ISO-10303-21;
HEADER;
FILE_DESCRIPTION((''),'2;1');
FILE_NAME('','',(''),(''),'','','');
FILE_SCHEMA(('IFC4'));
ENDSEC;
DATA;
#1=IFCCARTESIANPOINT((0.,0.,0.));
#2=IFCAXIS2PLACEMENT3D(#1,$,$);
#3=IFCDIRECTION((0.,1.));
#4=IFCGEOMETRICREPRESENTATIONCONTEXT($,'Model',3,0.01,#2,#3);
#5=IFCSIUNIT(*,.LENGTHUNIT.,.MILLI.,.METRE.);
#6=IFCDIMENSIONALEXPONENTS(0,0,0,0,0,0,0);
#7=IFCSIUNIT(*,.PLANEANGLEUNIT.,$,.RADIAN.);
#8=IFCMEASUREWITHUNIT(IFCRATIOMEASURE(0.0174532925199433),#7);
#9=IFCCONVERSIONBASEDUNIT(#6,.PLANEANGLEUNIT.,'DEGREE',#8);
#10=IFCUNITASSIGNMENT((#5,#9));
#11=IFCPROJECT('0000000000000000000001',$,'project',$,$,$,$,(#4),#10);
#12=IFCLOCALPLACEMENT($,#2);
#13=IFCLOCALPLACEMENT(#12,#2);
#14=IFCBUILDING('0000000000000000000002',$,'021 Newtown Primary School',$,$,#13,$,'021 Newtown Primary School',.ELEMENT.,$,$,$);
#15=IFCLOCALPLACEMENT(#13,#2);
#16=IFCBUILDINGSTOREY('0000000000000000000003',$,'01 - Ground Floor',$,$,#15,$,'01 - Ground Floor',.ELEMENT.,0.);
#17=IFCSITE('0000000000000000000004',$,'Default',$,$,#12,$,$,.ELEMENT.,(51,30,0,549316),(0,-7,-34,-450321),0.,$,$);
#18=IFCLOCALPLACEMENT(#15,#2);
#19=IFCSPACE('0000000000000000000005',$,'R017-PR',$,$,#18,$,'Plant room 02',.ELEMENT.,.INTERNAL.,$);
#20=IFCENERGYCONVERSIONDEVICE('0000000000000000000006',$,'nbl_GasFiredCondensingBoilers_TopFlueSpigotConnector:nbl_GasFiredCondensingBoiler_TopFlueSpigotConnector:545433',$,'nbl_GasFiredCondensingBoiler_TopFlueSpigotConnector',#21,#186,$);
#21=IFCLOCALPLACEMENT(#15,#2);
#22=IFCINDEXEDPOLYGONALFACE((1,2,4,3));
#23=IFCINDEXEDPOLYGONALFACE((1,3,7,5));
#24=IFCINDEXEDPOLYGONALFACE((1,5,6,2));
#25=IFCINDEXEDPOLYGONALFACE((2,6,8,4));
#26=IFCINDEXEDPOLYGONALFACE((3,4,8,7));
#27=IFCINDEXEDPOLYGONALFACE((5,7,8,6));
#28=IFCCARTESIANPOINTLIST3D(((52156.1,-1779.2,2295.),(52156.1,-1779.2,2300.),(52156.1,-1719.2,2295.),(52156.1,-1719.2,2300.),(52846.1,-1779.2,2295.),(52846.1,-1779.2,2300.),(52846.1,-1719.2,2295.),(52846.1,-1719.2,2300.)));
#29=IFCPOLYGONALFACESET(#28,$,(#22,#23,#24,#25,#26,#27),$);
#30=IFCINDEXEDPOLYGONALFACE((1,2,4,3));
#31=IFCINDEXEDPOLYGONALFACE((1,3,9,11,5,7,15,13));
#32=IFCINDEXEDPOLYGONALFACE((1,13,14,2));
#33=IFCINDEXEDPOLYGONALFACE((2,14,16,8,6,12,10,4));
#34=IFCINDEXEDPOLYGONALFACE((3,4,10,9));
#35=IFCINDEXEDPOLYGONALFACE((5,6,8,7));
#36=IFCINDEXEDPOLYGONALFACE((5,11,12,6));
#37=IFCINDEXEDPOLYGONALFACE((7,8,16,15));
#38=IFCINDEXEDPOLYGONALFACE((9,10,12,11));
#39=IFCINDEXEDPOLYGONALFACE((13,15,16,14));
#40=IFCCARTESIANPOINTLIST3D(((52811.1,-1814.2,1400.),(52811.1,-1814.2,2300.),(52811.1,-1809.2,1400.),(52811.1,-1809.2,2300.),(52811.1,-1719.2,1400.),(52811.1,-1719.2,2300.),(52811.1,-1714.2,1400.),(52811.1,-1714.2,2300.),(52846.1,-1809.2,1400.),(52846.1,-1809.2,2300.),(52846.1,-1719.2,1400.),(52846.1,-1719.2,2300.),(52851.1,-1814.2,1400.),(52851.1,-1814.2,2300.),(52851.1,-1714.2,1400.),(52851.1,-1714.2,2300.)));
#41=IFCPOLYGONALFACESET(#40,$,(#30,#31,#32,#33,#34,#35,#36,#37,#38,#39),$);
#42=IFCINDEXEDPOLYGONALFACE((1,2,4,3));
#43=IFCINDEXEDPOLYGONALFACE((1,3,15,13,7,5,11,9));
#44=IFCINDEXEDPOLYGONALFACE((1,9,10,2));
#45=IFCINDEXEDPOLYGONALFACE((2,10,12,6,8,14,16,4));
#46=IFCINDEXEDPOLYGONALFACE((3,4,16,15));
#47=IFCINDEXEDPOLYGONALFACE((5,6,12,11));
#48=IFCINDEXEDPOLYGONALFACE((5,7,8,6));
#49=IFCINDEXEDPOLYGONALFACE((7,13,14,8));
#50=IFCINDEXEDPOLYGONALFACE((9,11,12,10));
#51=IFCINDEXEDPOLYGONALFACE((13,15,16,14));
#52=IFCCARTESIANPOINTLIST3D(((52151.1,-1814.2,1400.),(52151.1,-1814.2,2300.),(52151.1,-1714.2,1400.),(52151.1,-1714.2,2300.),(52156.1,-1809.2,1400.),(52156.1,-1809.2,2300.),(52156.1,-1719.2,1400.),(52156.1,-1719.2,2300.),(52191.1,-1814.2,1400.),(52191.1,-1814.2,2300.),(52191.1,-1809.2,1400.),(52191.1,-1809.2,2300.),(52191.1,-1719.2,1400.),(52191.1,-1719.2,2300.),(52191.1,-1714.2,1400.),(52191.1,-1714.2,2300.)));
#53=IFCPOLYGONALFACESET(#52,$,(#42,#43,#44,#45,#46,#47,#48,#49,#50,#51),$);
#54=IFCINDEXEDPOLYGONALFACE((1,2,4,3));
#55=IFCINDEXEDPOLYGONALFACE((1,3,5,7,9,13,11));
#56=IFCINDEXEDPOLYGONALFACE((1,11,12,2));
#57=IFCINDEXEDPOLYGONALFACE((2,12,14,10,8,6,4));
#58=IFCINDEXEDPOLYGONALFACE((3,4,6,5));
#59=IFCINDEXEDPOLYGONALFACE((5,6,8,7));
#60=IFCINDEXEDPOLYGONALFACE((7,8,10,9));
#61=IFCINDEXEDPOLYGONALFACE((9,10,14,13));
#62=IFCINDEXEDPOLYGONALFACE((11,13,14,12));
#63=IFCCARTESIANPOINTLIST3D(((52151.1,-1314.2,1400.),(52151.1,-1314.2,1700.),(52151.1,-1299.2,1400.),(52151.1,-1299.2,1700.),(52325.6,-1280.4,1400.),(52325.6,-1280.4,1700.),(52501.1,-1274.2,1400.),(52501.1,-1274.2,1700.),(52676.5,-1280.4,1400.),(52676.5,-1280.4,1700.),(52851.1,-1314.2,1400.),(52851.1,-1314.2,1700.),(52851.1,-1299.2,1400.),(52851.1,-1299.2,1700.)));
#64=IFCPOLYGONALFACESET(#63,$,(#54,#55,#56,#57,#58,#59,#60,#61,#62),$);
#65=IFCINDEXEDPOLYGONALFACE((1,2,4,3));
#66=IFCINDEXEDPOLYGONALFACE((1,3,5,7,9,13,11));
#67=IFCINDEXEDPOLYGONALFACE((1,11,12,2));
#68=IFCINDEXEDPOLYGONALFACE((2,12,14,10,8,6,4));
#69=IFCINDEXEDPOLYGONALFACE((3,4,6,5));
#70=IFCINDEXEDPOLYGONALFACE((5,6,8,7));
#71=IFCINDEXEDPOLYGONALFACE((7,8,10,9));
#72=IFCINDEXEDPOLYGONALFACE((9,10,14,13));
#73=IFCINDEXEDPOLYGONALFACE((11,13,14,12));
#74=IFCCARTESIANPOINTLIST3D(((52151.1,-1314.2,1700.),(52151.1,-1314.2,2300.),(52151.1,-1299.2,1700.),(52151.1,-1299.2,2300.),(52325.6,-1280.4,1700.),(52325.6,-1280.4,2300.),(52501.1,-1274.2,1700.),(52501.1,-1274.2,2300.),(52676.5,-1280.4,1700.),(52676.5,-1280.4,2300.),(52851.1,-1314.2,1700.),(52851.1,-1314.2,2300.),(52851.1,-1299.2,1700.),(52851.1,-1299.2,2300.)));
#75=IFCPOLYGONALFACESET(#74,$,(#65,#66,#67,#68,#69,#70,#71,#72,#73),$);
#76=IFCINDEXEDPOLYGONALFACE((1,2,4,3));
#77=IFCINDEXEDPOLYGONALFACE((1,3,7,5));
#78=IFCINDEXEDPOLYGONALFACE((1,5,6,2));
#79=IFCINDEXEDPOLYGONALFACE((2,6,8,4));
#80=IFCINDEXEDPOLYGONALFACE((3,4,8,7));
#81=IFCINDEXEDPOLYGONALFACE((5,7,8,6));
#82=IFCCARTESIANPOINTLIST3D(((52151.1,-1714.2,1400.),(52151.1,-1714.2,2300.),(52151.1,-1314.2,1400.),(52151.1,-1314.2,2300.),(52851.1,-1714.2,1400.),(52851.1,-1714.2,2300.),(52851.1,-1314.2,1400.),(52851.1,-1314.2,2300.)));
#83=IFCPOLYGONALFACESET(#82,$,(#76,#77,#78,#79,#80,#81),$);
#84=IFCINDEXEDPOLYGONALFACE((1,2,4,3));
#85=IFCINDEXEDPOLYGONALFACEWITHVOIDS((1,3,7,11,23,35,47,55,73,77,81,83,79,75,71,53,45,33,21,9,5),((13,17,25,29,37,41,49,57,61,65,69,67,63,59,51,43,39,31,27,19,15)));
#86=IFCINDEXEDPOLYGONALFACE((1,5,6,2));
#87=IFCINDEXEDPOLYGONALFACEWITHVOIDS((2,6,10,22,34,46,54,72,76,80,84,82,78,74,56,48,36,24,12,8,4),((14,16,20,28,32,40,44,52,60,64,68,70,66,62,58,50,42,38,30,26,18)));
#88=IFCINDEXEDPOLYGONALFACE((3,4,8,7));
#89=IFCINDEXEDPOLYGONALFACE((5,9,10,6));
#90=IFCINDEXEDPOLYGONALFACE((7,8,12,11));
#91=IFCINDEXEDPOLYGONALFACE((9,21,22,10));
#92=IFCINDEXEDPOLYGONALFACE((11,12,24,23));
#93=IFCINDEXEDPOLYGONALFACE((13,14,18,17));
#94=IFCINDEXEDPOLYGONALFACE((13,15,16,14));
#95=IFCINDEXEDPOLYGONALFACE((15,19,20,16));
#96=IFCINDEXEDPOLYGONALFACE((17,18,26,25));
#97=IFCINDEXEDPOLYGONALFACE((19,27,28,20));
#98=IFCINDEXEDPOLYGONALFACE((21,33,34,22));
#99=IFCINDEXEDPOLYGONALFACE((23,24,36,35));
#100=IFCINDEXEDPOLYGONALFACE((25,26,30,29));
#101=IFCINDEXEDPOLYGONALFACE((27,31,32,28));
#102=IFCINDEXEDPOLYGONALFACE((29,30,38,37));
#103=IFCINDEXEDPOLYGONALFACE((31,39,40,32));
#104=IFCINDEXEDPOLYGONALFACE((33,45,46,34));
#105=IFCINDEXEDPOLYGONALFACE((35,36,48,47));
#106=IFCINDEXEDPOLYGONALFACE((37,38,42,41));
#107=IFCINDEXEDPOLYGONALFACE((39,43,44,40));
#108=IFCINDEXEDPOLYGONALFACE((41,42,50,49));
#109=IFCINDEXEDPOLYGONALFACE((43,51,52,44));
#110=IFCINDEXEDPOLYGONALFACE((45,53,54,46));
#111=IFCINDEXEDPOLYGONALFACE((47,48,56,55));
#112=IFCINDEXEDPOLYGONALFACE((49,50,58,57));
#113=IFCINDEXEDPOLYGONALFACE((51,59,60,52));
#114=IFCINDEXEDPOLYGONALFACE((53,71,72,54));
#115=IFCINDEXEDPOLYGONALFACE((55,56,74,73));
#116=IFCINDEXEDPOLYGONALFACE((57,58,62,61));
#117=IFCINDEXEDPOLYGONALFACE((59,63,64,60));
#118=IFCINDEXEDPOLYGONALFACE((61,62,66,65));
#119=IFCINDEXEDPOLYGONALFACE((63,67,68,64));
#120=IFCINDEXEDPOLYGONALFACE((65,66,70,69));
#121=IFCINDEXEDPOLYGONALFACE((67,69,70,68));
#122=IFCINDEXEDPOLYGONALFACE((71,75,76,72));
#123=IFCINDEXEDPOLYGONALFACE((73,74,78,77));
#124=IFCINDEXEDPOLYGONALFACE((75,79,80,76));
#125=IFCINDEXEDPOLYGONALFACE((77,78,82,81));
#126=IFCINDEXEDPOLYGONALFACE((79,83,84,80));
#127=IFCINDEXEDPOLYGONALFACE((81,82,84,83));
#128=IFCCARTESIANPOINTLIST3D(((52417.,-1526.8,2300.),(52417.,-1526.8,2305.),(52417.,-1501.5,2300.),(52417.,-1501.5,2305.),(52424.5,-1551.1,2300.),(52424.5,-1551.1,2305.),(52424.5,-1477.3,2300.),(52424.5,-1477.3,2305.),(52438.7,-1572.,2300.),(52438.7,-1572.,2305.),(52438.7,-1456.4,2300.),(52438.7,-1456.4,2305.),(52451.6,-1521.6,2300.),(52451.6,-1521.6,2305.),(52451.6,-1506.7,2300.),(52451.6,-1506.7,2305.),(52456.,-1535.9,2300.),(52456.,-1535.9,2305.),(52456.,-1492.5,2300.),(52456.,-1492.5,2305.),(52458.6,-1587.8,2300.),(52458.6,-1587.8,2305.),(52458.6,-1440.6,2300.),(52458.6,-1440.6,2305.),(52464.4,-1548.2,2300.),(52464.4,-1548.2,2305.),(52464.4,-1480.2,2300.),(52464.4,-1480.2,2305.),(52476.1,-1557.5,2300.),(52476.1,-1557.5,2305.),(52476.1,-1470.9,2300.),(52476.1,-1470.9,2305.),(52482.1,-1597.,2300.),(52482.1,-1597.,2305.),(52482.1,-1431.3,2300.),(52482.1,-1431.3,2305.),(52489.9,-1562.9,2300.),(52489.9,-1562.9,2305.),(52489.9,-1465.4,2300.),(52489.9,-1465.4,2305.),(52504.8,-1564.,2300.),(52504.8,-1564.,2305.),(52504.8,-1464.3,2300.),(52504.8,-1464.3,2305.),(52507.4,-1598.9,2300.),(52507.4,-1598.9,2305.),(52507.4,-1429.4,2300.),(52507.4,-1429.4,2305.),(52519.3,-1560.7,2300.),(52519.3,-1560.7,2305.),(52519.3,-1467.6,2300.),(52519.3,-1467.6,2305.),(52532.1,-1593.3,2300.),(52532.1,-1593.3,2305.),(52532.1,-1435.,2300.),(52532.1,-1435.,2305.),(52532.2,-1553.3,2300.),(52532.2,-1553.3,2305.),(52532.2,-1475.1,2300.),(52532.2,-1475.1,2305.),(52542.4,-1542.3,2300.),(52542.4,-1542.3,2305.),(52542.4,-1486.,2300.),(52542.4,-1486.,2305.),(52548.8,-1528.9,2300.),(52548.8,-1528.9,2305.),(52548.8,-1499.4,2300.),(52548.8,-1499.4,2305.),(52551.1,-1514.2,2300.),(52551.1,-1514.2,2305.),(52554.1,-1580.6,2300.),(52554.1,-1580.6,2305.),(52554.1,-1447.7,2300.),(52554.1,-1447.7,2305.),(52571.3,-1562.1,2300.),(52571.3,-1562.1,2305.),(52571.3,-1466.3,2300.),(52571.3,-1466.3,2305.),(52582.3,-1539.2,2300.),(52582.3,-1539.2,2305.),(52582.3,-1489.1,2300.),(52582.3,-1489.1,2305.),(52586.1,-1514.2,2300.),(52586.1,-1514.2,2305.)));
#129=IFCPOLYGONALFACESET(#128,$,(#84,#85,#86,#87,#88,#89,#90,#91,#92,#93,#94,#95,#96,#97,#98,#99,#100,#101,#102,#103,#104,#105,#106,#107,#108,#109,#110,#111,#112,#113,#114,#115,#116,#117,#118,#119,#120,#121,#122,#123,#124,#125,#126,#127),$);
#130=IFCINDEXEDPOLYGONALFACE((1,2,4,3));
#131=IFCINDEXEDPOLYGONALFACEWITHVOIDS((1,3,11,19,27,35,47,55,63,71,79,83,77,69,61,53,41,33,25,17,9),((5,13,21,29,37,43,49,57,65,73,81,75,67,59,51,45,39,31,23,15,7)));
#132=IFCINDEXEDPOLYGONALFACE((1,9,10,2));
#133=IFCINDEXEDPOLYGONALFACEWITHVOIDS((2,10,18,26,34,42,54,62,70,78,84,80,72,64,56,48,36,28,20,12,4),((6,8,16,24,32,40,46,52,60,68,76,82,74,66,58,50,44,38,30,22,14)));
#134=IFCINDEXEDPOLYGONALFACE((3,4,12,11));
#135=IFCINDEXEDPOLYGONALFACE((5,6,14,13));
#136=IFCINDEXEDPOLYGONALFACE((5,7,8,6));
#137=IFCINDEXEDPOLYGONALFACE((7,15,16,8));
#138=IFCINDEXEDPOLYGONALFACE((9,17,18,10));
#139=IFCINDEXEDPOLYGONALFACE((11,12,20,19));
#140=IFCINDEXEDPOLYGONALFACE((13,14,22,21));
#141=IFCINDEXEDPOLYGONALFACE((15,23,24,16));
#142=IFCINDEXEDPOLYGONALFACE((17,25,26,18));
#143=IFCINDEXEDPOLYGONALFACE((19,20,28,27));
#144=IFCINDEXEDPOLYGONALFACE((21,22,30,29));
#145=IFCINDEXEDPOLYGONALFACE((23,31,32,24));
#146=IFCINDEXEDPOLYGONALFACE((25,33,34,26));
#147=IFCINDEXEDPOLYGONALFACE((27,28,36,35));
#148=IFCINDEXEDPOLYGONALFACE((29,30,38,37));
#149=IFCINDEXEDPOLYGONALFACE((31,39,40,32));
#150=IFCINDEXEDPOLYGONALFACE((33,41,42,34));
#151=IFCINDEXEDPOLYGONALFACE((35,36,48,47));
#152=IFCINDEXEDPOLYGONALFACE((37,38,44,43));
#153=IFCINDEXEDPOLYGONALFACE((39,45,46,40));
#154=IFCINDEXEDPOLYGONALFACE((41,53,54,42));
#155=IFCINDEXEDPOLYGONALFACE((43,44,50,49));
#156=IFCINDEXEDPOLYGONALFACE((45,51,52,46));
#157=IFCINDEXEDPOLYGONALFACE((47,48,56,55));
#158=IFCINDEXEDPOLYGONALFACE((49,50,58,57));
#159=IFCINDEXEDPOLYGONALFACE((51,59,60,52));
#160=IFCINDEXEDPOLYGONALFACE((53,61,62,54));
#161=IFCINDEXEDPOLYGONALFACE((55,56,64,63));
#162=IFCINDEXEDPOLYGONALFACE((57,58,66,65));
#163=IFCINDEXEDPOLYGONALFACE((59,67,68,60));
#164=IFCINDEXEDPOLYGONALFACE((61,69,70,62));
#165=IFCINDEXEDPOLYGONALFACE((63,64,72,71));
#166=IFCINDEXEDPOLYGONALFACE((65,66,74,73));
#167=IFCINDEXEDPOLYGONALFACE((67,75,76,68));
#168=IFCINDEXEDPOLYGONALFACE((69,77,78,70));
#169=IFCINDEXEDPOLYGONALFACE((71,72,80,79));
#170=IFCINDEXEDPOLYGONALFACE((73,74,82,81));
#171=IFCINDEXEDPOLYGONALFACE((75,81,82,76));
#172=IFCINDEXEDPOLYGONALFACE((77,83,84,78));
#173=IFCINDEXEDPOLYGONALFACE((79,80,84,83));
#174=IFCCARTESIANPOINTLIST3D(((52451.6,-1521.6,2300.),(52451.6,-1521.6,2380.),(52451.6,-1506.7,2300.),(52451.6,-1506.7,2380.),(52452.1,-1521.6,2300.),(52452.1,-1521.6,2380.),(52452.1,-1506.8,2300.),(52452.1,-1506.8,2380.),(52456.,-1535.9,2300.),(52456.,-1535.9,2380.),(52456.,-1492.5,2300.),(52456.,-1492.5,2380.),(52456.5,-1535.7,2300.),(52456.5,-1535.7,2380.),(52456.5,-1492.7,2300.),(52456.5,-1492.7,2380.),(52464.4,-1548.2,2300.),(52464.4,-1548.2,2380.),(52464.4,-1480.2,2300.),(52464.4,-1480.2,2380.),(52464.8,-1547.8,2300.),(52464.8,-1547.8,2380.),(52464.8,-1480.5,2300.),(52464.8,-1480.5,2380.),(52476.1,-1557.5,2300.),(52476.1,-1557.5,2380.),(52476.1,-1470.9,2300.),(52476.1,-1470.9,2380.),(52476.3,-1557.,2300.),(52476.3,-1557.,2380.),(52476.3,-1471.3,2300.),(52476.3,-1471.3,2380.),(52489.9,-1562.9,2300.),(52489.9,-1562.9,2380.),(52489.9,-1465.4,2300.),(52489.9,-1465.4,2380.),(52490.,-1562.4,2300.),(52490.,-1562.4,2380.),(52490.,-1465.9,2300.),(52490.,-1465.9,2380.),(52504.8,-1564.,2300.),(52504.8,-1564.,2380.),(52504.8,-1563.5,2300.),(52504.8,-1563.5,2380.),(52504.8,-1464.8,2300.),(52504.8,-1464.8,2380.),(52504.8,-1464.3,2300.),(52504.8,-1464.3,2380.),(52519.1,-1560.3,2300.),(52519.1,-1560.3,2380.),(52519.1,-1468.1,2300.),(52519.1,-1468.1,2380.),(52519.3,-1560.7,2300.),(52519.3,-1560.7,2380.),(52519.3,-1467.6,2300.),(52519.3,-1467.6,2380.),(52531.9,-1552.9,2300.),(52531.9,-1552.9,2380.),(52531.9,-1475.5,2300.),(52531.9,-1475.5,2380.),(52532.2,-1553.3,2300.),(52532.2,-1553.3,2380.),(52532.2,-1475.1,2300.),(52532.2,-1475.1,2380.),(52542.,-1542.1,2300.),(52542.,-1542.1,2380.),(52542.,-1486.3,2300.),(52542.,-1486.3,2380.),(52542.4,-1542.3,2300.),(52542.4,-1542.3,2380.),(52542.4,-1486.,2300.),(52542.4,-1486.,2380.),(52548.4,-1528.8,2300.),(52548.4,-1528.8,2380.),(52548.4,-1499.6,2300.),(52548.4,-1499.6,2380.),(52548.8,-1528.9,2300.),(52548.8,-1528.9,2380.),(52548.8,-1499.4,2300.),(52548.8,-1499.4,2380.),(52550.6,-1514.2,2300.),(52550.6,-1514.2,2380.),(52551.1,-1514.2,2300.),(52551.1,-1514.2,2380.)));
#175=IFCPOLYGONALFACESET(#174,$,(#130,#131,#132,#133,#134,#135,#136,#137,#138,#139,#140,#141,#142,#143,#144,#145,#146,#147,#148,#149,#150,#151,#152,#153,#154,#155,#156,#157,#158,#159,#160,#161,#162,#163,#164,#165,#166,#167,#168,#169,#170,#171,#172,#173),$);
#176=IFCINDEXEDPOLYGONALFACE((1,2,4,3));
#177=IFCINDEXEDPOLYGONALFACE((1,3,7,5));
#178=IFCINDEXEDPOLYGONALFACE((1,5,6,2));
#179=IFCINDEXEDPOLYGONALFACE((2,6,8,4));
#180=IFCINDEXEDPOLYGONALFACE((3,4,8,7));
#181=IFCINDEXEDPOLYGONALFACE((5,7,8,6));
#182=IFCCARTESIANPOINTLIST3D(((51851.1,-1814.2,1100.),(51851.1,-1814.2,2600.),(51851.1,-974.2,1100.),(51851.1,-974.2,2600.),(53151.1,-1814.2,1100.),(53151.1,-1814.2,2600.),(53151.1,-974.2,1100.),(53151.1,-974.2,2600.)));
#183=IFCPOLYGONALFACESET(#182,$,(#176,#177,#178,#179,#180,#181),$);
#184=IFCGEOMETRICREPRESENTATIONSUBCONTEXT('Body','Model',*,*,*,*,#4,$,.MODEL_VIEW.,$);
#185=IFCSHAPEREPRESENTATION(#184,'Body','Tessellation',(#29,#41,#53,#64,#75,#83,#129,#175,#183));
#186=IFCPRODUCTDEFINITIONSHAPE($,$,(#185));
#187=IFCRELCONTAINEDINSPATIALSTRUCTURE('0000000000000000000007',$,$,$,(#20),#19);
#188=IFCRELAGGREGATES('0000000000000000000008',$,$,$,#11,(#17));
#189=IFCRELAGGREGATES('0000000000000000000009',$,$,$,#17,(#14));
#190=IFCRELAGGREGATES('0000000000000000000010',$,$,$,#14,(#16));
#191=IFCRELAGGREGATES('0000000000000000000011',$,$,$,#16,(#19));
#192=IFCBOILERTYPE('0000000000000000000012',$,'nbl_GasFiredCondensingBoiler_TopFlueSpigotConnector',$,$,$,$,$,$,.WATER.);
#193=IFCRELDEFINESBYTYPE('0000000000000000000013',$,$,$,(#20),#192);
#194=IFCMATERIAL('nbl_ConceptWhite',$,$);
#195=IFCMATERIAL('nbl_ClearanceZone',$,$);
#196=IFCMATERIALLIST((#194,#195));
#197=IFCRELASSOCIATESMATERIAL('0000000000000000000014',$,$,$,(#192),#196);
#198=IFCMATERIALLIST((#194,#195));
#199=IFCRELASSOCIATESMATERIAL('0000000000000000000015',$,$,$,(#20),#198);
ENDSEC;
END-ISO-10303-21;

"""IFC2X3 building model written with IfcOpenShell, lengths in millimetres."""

from ifc_helpers import new_model, entity, si_unit, converted_unit, direction, frame, frame_2d, origin, origin_2d_with_axis, place, context, subcontext, project, spatial, polyline, circle_curve, parameter, trimmed, segment, composite_curve, rectangle, hollow_circle, outline, extrude, source, transform, mapped, material, material_list, type_object, type_shapes, element, save


model = new_model("IFC2X3")

# Units and contexts
model_context = context("Model", 3, precision=0.01, world=origin(), true_north=direction((0.0, 1.0)))
body_context = subcontext(model_context, "Body", "Model", "MODEL_VIEW")
ifc_project = project(units=[si_unit("LENGTHUNIT", "METRE", prefix="MILLI"), converted_unit("PLANEANGLEUNIT", "DEGREE", entity("IfcRatioMeasure", 0.0174532925199433), si_unit("PLANEANGLEUNIT", "RADIAN"), dimensions=[0, 0, 0, 0, 0, 0, 0])], contexts=[model_context])

# Site, building, storey
site_placement = place(None, origin())
site = spatial("IfcSite", under=ifc_project, at=site_placement, Name="Default", CompositionType="ELEMENT", RefLatitude=(51, 30, 0, 549316), RefLongitude=(0, -7, -34, -450321), RefElevation=0.0)
building_placement = place(site_placement, origin())
building = spatial("IfcBuilding", under=site, at=building_placement, Name="021 Newtown Primary School", LongName="021 Newtown Primary School", CompositionType="ELEMENT")
storey_placement = place(building_placement, origin())
storey = spatial("IfcBuildingStorey", under=building, at=storey_placement, Name="01 - Ground Floor", LongName="01 - Ground Floor", CompositionType="ELEMENT", Elevation=0.0)

# Shared definitions
space_placement = place(storey_placement, origin())
space = spatial("IfcSpace", under=storey, at=space_placement, Name="R017-PR", LongName="Plant room 02", CompositionType="ELEMENT", InteriorOrExteriorSpace="INTERNAL")

# Energy conversion device
ifc_material_1 = material(Name="nbl_ConceptWhite")
ifc_material_2 = material(Name="nbl_ClearanceZone")
ifc_material_list_1 = material_list([ifc_material_1, ifc_material_2])
boiler_type = type_object("IfcBoilerType", Name="nbl_GasFiredCondensingBoiler_TopFlueSpigotConnector", PredefinedType="WATER", material=ifc_material_list_1)
shared_shape = source(origin(), body_context, "Body", "SweptSolid", [
    extrude(rectangle(XDim=690.0, YDim=60.0, at=origin_2d_with_axis()), frame((0.0, 65.0, 895.0), z_axis=(0.0, 0.0, 1.0), x_axis=(-1.0, 0.0, 0.0)), (0.0, 0.0, 1.0), 5.0),
    extrude(outline(polyline([(-21.2, -50.0), (18.8, -50.0), (18.8, -45.0), (-16.2, -45.0), (-16.3, 45.0), (18.7, 45.0), (18.7, 50.0), (-21.2, 50.0), (-21.2, -50.0)])), frame((328.7, 50.0, 0.0), z_axis=(0.0, 0.0, 1.0), x_axis=(-1.0, 0.0, 0.0)), (0.0, 0.0, 1.0), 900.0),
    extrude(outline(polyline([(-50.0, -21.3), (50.0, -21.3), (50.0, 18.8), (45.0, 18.8), (45.0, -16.2), (-45.0, -16.3), (-45.0, 18.7), (-50.0, 18.7), (-50.0, -21.3)])), frame((-328.8, 50.0, 0.0), z_axis=(0.0, 0.0, 1.0), x_axis=(0.0, -1.0, 0.0)), (0.0, 0.0, 1.0), 900.0),
    extrude(outline(composite_curve([segment(polyline([(-7.5, -350.0), (7.5, -350.0)]), True, "CONTINUOUS"), segment(trimmed(circle_curve(frame_2d((-2430.0, 0.0), x_axis=(0.0, -1.0)), 2462.5), [parameter(81.828766)], [parameter(98.171234)], True, "PARAMETER"), True, "CONTINUOUS"), segment(polyline([(7.5, 350.0), (-7.5, 350.0)]), True, "CONTINUOUS"), segment(polyline([(-7.5, 350.0), (-7.5, -350.0)]), True, "CONTINUOUS")], self_intersect=False)), frame((0.0, 507.5, 0.0), z_axis=(0.0, 0.0, 1.0), x_axis=(0.0, 1.0, 0.0)), (0.0, 0.0, 1.0), 300.0),
    extrude(outline(composite_curve([segment(polyline([(-350.0, -7.5), (350.0, -7.5)]), True, "CONTINUOUS"), segment(polyline([(350.0, -7.5), (350.0, 7.5)]), True, "CONTINUOUS"), segment(trimmed(circle_curve(frame_2d((0.0, -2430.0), x_axis=(1.0, 0.0)), 2462.5), [parameter(81.828766)], [parameter(98.171234)], True, "PARAMETER"), True, "CONTINUOUS"), segment(polyline([(-350.0, 7.5), (-350.0, -7.5)]), True, "CONTINUOUS")], self_intersect=False)), frame((0.0, 507.5, 300.0)), (0.0, 0.0, 1.0), 600.0),
    extrude(rectangle(XDim=700.0, YDim=400.0, at=origin_2d_with_axis()), frame((0.0, 300.0, 0.0), z_axis=(0.0, 0.0, 1.0), x_axis=(-1.0, 0.0, 0.0)), (0.0, 0.0, 1.0), 900.0),
    extrude(hollow_circle(Radius=85.0, WallThickness=35.0, at=frame_2d((0.0, 0.0), x_axis=(1.0, 0.0))), frame((0.0, 300.0, 900.0)), (0.0, 0.0, 1.0), 5.0),
    extrude(hollow_circle(Radius=50.0, WallThickness=0.5, at=frame_2d((0.0, 0.0), x_axis=(1.0, 0.0))), frame((0.0, 300.0, 900.0)), (0.0, 0.0, 1.0), 80.0),
    extrude(rectangle(XDim=840.0, YDim=1300.0, at=origin_2d_with_axis()), frame((0.0, 420.0, -300.0), z_axis=(0.0, 0.0, 1.0), x_axis=(0.0, 1.0, 0.0)), (0.0, 0.0, 1.0), 1500.0),
])
type_shapes(boiler_type, [shared_shape])
ifc_material_list_2 = material_list([ifc_material_1, ifc_material_2])
energy_conversion_device_1_placement = place(space_placement, frame((52501.1, -1814.2, 1400.0)))
element("IfcEnergyConversionDevice", 1, at=energy_conversion_device_1_placement, inside=space, type_object=boiler_type, material=ifc_material_list_2, Name="nbl_GasFiredCondensingBoilers_TopFlueSpigotConnector:nbl_GasFiredCondensingBoiler_TopFlueSpigotConnector:545433", ObjectType="nbl_GasFiredCondensingBoiler_TopFlueSpigotConnector", context=body_context, shape_type="MappedRepresentation", body=[
    mapped(shared_shape, transform((0.0, 0.0, 0.0), scale=1.0)),
])

save(model, "model.ifc")
